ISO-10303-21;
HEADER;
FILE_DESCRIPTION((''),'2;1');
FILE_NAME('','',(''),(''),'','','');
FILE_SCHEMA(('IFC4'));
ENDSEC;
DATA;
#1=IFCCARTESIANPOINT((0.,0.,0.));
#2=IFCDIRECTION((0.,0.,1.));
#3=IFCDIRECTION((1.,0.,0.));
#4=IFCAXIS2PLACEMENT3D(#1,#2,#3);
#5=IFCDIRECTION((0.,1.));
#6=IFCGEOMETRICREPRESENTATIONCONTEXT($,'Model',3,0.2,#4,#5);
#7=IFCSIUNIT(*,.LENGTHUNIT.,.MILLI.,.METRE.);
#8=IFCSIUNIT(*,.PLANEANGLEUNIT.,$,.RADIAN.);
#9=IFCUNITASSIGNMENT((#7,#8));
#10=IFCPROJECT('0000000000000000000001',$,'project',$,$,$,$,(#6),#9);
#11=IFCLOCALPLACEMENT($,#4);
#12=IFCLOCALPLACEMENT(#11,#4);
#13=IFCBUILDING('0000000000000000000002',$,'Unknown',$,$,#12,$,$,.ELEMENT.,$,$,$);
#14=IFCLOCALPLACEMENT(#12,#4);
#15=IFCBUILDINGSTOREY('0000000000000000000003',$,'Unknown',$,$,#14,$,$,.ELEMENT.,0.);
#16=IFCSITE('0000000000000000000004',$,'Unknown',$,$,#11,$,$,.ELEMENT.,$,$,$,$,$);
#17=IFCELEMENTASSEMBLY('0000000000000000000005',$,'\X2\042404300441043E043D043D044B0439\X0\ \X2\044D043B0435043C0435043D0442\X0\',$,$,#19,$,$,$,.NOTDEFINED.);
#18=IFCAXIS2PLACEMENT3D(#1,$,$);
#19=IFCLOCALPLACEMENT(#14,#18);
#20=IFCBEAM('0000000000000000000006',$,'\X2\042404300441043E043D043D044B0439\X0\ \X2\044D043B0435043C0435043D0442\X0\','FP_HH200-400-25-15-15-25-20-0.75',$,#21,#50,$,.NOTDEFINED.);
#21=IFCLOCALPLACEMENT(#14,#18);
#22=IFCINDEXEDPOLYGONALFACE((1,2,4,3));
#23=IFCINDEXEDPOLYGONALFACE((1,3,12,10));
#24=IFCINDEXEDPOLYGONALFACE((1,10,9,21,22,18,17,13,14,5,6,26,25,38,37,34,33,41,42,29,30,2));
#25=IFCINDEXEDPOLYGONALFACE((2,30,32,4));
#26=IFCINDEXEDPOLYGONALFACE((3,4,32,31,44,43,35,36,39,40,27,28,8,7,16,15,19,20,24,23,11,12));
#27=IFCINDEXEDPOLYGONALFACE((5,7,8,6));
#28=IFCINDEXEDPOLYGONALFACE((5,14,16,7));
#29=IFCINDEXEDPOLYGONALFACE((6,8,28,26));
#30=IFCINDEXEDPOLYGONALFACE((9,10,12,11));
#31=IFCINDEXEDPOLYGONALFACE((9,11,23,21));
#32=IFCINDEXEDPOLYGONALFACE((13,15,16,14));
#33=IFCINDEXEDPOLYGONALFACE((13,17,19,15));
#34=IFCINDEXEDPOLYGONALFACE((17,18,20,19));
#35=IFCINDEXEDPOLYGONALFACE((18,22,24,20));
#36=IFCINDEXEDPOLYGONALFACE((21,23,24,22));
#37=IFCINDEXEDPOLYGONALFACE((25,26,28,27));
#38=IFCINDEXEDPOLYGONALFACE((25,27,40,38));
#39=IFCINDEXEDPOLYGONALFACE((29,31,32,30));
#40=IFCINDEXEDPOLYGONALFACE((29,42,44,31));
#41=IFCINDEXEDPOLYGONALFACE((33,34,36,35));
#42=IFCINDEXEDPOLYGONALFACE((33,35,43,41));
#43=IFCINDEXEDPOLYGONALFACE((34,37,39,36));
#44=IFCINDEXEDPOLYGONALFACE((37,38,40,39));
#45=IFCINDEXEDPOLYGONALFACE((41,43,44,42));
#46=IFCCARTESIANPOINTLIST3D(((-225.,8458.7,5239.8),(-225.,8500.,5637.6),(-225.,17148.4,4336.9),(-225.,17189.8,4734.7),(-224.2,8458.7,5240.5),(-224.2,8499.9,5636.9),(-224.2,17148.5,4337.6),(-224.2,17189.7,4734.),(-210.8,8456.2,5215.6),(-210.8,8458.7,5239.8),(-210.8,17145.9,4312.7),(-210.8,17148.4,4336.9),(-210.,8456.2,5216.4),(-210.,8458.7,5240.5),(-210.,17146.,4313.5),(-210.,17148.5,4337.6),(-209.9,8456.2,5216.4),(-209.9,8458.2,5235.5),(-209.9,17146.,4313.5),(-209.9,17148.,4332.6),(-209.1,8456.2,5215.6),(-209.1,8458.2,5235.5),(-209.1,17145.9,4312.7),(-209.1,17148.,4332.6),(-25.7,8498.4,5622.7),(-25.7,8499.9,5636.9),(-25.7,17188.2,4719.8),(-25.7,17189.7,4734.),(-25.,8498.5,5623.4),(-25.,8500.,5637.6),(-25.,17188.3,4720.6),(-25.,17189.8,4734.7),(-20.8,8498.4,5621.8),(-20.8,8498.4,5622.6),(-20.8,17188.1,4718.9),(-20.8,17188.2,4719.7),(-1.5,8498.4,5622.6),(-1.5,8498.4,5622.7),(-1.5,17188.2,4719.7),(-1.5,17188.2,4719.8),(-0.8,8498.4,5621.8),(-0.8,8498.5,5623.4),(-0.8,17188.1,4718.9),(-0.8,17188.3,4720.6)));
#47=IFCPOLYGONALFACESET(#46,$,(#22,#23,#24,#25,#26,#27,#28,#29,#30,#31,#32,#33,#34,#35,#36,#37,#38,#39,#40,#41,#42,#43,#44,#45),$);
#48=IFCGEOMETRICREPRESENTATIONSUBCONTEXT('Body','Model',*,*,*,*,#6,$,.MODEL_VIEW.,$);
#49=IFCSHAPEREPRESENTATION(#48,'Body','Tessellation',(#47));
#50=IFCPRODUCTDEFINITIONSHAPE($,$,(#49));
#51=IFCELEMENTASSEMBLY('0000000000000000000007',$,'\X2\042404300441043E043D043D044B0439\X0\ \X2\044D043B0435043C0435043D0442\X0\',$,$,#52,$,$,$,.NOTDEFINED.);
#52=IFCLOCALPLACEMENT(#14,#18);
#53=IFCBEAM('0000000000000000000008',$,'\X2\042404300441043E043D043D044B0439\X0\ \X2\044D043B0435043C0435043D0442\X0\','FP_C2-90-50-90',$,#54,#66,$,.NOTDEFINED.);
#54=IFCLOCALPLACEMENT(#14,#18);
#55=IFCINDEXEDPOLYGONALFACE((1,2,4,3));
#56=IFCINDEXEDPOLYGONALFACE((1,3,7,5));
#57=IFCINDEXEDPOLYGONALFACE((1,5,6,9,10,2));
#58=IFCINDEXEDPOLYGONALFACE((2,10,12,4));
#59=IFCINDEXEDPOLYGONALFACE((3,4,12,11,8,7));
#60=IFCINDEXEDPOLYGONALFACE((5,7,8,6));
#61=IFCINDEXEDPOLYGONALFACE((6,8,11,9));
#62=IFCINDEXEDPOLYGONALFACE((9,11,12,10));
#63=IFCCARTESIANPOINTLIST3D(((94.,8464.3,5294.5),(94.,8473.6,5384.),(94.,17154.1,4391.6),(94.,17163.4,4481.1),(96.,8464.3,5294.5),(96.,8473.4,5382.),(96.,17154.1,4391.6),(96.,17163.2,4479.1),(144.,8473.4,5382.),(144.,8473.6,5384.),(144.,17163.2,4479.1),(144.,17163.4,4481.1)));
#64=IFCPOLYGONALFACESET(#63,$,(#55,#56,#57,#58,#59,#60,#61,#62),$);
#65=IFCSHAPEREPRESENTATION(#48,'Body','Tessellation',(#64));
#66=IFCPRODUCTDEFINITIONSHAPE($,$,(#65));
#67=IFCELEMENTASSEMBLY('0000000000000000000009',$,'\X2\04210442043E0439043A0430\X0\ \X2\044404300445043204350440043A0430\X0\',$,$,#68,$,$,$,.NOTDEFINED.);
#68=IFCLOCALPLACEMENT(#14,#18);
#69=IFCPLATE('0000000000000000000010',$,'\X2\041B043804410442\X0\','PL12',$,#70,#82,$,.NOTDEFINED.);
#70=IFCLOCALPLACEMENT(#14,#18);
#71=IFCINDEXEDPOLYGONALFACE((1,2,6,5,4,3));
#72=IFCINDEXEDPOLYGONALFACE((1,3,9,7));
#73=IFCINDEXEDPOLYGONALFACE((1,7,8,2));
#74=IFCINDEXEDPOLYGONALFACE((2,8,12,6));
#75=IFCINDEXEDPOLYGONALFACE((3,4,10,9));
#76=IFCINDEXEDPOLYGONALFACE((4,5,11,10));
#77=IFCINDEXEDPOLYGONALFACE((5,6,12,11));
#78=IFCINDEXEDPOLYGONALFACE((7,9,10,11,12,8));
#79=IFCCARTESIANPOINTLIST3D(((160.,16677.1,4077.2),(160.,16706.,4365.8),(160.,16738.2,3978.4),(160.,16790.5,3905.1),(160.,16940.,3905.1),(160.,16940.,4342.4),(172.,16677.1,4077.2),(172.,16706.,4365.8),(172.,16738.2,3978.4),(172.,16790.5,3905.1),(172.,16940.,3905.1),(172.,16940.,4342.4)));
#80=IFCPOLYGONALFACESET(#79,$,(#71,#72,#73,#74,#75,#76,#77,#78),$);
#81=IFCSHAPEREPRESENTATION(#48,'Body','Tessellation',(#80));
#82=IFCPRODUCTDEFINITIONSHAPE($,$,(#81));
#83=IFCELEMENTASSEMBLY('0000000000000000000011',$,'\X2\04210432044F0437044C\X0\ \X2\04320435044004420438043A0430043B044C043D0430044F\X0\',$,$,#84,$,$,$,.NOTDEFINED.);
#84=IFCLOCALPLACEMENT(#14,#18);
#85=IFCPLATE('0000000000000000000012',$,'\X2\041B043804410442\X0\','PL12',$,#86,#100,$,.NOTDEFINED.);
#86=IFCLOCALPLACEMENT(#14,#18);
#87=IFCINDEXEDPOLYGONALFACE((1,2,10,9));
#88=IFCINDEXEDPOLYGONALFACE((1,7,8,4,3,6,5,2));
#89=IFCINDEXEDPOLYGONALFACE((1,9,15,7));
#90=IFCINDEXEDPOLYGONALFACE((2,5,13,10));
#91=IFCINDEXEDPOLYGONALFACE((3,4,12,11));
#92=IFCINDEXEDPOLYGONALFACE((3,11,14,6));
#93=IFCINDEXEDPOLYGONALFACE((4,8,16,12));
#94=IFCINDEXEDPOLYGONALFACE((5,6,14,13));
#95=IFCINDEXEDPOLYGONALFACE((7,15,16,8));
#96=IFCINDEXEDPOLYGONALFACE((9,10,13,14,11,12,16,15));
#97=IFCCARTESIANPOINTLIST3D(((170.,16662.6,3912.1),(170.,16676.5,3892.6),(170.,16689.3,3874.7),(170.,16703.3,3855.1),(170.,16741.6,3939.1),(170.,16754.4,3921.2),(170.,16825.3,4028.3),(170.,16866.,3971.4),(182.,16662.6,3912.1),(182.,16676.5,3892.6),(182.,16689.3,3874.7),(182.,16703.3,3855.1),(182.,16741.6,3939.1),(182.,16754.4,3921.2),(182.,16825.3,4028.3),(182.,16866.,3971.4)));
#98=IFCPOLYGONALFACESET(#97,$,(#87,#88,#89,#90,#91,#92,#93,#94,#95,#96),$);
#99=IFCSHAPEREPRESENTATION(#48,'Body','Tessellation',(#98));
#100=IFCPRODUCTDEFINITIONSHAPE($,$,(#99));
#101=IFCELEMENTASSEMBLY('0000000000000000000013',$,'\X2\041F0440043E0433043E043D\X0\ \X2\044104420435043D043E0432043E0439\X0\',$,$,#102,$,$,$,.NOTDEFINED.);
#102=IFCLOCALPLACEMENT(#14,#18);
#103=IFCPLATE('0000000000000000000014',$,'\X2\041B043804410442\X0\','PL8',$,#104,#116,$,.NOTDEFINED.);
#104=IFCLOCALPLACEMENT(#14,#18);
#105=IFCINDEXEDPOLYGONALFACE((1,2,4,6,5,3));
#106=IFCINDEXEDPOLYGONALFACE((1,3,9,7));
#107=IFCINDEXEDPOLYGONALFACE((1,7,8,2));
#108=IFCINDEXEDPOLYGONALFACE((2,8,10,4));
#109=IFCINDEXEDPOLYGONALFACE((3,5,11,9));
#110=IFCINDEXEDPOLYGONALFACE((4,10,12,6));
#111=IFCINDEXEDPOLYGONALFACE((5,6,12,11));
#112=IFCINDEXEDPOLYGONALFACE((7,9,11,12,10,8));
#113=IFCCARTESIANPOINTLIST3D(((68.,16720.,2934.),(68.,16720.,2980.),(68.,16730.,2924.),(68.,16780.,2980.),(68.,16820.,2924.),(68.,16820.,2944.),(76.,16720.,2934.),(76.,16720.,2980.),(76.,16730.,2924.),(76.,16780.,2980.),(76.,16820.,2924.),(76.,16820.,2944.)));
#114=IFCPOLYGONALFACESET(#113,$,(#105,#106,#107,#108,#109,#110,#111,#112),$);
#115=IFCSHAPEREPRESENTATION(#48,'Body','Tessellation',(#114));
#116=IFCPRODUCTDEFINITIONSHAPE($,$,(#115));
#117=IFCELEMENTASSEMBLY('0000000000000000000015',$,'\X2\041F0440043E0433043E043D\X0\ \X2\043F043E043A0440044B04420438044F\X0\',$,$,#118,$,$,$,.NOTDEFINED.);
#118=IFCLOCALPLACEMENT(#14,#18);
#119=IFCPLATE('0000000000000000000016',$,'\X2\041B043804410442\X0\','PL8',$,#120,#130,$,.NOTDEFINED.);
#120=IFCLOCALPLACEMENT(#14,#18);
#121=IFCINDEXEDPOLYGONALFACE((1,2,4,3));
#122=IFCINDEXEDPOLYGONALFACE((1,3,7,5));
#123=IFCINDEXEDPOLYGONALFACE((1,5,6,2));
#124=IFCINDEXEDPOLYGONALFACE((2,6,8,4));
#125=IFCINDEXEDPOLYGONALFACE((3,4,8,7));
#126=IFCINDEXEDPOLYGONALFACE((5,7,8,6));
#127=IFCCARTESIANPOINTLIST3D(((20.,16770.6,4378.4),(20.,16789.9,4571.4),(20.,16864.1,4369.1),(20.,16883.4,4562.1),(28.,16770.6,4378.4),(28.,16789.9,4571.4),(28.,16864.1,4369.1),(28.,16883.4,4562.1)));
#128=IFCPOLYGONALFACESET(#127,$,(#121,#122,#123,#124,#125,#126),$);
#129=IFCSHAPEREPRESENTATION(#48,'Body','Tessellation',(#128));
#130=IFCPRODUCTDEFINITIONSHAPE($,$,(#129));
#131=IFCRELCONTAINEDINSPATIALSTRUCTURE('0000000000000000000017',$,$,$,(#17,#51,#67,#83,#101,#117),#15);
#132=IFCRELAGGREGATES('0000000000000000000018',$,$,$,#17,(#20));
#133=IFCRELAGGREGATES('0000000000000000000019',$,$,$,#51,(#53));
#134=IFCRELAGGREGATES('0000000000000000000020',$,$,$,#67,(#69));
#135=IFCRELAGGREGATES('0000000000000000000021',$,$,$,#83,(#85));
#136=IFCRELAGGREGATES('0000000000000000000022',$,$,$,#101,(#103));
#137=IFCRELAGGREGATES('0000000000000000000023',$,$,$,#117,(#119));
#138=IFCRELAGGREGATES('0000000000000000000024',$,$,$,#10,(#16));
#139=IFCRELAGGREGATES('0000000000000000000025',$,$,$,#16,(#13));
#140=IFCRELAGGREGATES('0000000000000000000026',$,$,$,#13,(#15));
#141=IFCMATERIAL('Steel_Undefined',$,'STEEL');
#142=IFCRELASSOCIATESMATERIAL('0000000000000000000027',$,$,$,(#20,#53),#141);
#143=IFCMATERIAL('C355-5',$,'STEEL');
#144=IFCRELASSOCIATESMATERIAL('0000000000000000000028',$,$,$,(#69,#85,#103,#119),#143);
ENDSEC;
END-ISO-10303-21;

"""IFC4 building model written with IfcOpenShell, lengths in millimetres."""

from ifc_helpers import new_model, si_unit, direction, frame, origin_with_axes, place, context, subcontext, project, spatial, line, indexed_curve, outline, extrude, material, element, aggregate, save


model = new_model("IFC4")

# Units and contexts
model_context = context("Model", 3, precision=0.2, world=origin_with_axes(), true_north=direction((0.0, 1.0)))
body_context = subcontext(model_context, "Body", "Model", "MODEL_VIEW")
ifc_project = project(units=[si_unit("LENGTHUNIT", "METRE", prefix="MILLI"), si_unit("PLANEANGLEUNIT", "RADIAN")], contexts=[model_context])

# Site, building, storey
site_placement = place(None, origin_with_axes())
site = spatial("IfcSite", under=ifc_project, at=site_placement, Name="Unknown", CompositionType="ELEMENT")
building_placement = place(site_placement, origin_with_axes())
building = spatial("IfcBuilding", under=site, at=building_placement, Name="Unknown", CompositionType="ELEMENT")
storey_placement = place(building_placement, origin_with_axes())
storey = spatial("IfcBuildingStorey", under=building, at=storey_placement, Name="Unknown", CompositionType="ELEMENT", Elevation=0.0)

# Element assemblies, beams
ifc_material_1 = material(Name="Steel_Undefined", Category="STEEL")
assembly_1_placement = place(storey_placement, frame((-125.0, 17169.1, 4535.8), z_axis=(0.0, 0.103345, 0.994646), x_axis=(0.0, -0.994646, 0.103345)))
assembly_1 = element("IfcElementAssembly", 1, at=assembly_1_placement, inside=storey, Name="Фасонный элемент", PredefinedType="NOTDEFINED")
beam_1_placement = place(assembly_1_placement, origin_with_axes())
beam_1 = element("IfcBeam", 2, at=beam_1_placement, material=ifc_material_1, Name="Фасонный элемент", Description="FP_HH200-400-25-15-15-25-20-0.75", PredefinedType="NOTDEFINED", context=body_context, shape_type="SolidModel", body=[
    extrude(outline(indexed_curve([(-200.0, -100.0), (200.0, -100.0), (200.0, 100.0), (185.8, 100.0), (185.8, 124.2), (184.1, 124.2), (184.1, 104.2), (184.9, 104.2), (184.9, 123.5), (185.0, 123.5), (185.0, 99.2), (199.2, 99.2), (199.2, -99.2), (-199.2, -99.2), (-199.2, -85.0), (-223.5, -85.0), (-223.5, -84.9), (-204.2, -84.9), (-204.2, -84.1), (-224.2, -84.1), (-224.2, -85.8), (-200.0, -85.8)], segments=[line(1, 2, 3, 4, 5, 6, 7, 8, 9, 10, 11, 12, 13, 14, 15, 16, 17, 18, 19, 20, 21, 22, 1)])), frame((0.0, 0.0, 0.0), z_axis=(-1.0, 0.0, 0.0), x_axis=(0.0, 0.0, 1.0)), (0.0, 0.0, -1.0), 8736.6),
])
aggregate(assembly_1, [beam_1])
assembly_2_placement = place(storey_placement, frame((95.0, 17158.8, 4436.3), z_axis=(0.0, 0.103345, 0.994646), x_axis=(0.0, -0.994646, 0.103345)))
assembly_2 = element("IfcElementAssembly", 3, at=assembly_2_placement, inside=storey, Name="Фасонный элемент", PredefinedType="NOTDEFINED")
beam_2_placement = place(assembly_2_placement, origin_with_axes())
beam_2 = element("IfcBeam", 4, at=beam_2_placement, material=ifc_material_1, Name="Фасонный элемент", Description="FP_C2-90-50-90", PredefinedType="NOTDEFINED", context=body_context, shape_type="SolidModel", body=[
    extrude(outline(indexed_curve([(-45.0, -1.0), (45.0, -1.0), (45.0, 49.0), (43.0, 49.0), (43.0, 1.0), (-45.0, 1.0)], segments=[line(1, 2, 3, 4, 5, 6, 1)])), frame((0.0, 0.0, 0.0), z_axis=(-1.0, 0.0, 0.0), x_axis=(0.0, 0.0, 1.0)), (0.0, 0.0, -1.0), 8736.6),
])
aggregate(assembly_2, [beam_2])

# Element assembly, plate
assembly_3_placement = place(storey_placement, frame((80.0, 16920.0, -200.0), z_axis=(0.0, -1.0, 0.0), x_axis=(0.0, 0.0, 1.0)))
assembly_3 = element("IfcElementAssembly", 5, at=assembly_3_placement, inside=storey, Name="Стойка фахверка", PredefinedType="NOTDEFINED")
ifc_material_2 = material(Name="C355-5", Category="STEEL")
plate_1_placement = place(assembly_3_placement, frame((4105.1, -86.0, -20.0), z_axis=(0.0, 1.0, 0.0), x_axis=(0.0, 0.0, 1.0)))
plate_1 = element("IfcPlate", 6, at=plate_1_placement, material=ifc_material_2, Name="Лист", Description="PL12", PredefinedType="NOTDEFINED", context=body_context, shape_type="SolidModel", body=[
    extrude(outline(indexed_curve([(0.0, 0.0), (149.5, 0.0), (201.8, 73.2), (262.9, 172.1), (234.0, 460.7), (0.0, 437.3)], segments=[line(1, 2, 3, 4, 5, 6, 1)])), frame((0.0, 0.0, 6.0), z_axis=(0.0, 0.0, 1.0), x_axis=(1.0, 0.0, 0.0)), (0.0, 0.0, -1.0), 12.0),
])
aggregate(assembly_3, [plate_1])

# Element assembly, plate
assembly_4_placement = place(storey_placement, frame((176.0, 16920.0, 4052.9), z_axis=(-1.0, 0.0, 0.0), x_axis=(0.0, -0.813776, -0.581179)))
assembly_4 = element("IfcElementAssembly", 7, at=assembly_4_placement, inside=storey, Name="Связь вертикальная", PredefinedType="NOTDEFINED")
plate_2_placement = place(assembly_4_placement, frame((291.3, -35.0, 0.0), z_axis=(0.0, 0.0, -1.0), x_axis=(-1.0, 0.0, 0.0)))
plate_2 = element("IfcPlate", 8, at=plate_2_placement, material=ifc_material_2, Name="Лист", Description="PL12", PredefinedType="NOTDEFINED", context=body_context, shape_type="SolidModel", body=[
    extrude(outline(indexed_curve([(0.0, 0.0), (200.0, 0.0), (200.0, 70.0), (0.0, 70.0), (0.0, 46.0), (80.0, 46.0), (80.0, 24.0), (0.0, 24.0)], segments=[line(1, 2, 3, 4, 5, 6, 7, 8, 1)])), frame((0.0, 0.0, 6.0), z_axis=(0.0, 0.0, 1.0), x_axis=(1.0, 0.0, 0.0)), (0.0, 0.0, -1.0), 12.0),
])
aggregate(assembly_4, [plate_2])

# Element assemblies, plates
assembly_5_placement = place(storey_placement, frame((50.0, 17000.0, 2920.0), z_axis=(0.0, 0.0, -1.0), x_axis=(0.0, -1.0, 0.0)))
assembly_5 = element("IfcElementAssembly", 9, at=assembly_5_placement, inside=storey, Name="Прогон стеновой", PredefinedType="NOTDEFINED")
plate_3_placement = place(assembly_5_placement, frame((180.0, -22.0, -60.0), z_axis=(0.0, 1.0, 0.0), x_axis=(0.0, 0.0, 1.0)))
plate_3 = element("IfcPlate", 10, at=plate_3_placement, material=ifc_material_2, Name="Лист", Description="PL8", PredefinedType="NOTDEFINED", context=body_context, shape_type="SolidModel", body=[
    extrude(outline(indexed_curve([(0.0, 40.0), (36.0, 0.0), (56.0, 0.0), (56.0, 90.0), (46.0, 100.0), (0.0, 100.0)], segments=[line(1, 2, 3, 4, 5, 6, 1)])), frame((0.0, 0.0, 4.0), z_axis=(0.0, 0.0, 1.0), x_axis=(1.0, 0.0, 0.0)), (0.0, 0.0, -1.0), 8.0),
])
aggregate(assembly_5, [plate_3])
assembly_6_placement = place(storey_placement, frame((6000.0, 16827.0, 4470.2), z_axis=(0.0, -0.995037, 0.099504), x_axis=(-1.0, 0.0, 0.0)))
assembly_6 = element("IfcElementAssembly", 11, at=assembly_6_placement, inside=storey, Name="Прогон покрытия", PredefinedType="NOTDEFINED")
plate_4_placement = place(assembly_6_placement, frame((5976.0, -97.0, 47.0), z_axis=(1.0, 0.0, 0.0), x_axis=(0.0, 0.0, -1.0)))
plate_4 = element("IfcPlate", 12, at=plate_4_placement, material=ifc_material_2, Name="Лист", Description="PL8", PredefinedType="NOTDEFINED", context=body_context, shape_type="SolidModel", body=[
    extrude(outline(indexed_curve([(0.0, 0.0), (94.0, 0.0), (94.0, 194.0), (0.0, 194.0)], segments=[line(1, 2, 3, 4, 1)])), frame((0.0, 0.0, 4.0), z_axis=(0.0, 0.0, 1.0), x_axis=(1.0, 0.0, 0.0)), (0.0, 0.0, -1.0), 8.0),
])
aggregate(assembly_6, [plate_4])

save(model, "model.ifc")
